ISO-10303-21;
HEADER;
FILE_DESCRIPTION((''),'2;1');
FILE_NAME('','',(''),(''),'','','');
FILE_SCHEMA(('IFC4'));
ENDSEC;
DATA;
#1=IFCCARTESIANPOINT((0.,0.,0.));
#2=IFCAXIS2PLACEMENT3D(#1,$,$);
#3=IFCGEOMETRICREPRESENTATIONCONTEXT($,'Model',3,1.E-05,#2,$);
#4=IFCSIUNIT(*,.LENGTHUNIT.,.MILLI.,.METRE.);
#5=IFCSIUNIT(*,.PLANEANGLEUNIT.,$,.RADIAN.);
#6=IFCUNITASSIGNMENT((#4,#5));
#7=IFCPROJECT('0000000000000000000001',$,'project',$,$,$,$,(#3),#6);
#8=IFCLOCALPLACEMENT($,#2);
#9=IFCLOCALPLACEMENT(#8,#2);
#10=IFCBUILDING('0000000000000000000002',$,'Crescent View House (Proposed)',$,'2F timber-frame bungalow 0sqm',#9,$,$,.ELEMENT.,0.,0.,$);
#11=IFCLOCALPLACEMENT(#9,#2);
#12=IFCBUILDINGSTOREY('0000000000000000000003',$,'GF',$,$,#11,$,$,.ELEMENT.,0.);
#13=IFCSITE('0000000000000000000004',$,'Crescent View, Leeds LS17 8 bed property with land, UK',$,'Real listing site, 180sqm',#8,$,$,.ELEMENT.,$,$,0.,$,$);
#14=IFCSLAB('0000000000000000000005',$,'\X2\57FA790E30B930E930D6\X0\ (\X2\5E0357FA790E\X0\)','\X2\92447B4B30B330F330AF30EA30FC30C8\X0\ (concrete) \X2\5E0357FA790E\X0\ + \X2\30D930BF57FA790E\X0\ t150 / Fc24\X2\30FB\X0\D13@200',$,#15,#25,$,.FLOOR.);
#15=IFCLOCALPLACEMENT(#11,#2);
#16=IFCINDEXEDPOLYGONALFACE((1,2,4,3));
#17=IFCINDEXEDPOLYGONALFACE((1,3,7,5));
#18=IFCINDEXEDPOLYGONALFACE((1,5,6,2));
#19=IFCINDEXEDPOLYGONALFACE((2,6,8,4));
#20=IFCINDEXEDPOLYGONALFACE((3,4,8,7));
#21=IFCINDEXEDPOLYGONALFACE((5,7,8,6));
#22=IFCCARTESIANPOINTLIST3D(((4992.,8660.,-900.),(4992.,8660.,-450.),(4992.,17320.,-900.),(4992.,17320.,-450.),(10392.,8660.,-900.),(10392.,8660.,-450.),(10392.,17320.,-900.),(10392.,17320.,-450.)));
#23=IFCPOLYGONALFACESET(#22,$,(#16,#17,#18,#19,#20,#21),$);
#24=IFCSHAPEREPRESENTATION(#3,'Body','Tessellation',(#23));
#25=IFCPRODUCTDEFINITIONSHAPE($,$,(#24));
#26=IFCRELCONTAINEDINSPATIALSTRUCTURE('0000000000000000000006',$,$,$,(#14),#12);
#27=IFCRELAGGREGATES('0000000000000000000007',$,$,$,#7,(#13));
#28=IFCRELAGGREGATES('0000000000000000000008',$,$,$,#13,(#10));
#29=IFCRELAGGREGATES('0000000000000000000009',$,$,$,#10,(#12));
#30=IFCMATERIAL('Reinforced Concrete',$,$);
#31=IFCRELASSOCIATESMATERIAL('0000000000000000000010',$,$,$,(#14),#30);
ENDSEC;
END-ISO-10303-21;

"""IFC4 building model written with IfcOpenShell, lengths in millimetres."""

from ifc_helpers import new_model, si_unit, frame, frame_2d, origin, place, context, project, spatial, rectangle, extrude, material, element, save


model = new_model("IFC4")

# Units and contexts
model_context = context("Model", 3, precision=1e-05, world=origin())
ifc_project = project(units=[si_unit("LENGTHUNIT", "METRE", prefix="MILLI"), si_unit("PLANEANGLEUNIT", "RADIAN")], contexts=[model_context])

# Site, building, storey
site_placement = place(None, origin())
site = spatial("IfcSite", under=ifc_project, at=site_placement, Name="Crescent View, Leeds LS17 8 bed property with land, UK", ObjectType="Real listing site, 180sqm", CompositionType="ELEMENT", RefElevation=0.0)
building_placement = place(site_placement, origin())
building = spatial("IfcBuilding", under=site, at=building_placement, Name="Crescent View House (Proposed)", ObjectType="2F timber-frame bungalow 0sqm", CompositionType="ELEMENT", ElevationOfRefHeight=0.0, ElevationOfTerrain=0.0)
storey_placement = place(building_placement, origin())
storey = spatial("IfcBuildingStorey", under=building, at=storey_placement, Name="GF", CompositionType="ELEMENT", Elevation=0.0)

# Slab
ifc_material_1 = material(Name="Reinforced Concrete")
slab_1_placement = place(storey_placement, frame((2496.0, 4330.0, -450.0)))
element("IfcSlab", 1, at=slab_1_placement, inside=storey, material=ifc_material_1, Name="基礎スラブ (布基礎)", Description="鉄筋コンクリート (concrete) 布基礎 + ベタ基礎 t150 / Fc24・D13@200", PredefinedType="FLOOR", context=model_context, shape_type="SweptSolid", body=[
    extrude(rectangle(XDim=5400.0, YDim=8660.0, at=frame_2d((2700.0, 4330.0))), frame((2496.0, 4330.0, -450.0)), (0.0, 0.0, 1.0), 450.0),
])

save(model, "model.ifc")
